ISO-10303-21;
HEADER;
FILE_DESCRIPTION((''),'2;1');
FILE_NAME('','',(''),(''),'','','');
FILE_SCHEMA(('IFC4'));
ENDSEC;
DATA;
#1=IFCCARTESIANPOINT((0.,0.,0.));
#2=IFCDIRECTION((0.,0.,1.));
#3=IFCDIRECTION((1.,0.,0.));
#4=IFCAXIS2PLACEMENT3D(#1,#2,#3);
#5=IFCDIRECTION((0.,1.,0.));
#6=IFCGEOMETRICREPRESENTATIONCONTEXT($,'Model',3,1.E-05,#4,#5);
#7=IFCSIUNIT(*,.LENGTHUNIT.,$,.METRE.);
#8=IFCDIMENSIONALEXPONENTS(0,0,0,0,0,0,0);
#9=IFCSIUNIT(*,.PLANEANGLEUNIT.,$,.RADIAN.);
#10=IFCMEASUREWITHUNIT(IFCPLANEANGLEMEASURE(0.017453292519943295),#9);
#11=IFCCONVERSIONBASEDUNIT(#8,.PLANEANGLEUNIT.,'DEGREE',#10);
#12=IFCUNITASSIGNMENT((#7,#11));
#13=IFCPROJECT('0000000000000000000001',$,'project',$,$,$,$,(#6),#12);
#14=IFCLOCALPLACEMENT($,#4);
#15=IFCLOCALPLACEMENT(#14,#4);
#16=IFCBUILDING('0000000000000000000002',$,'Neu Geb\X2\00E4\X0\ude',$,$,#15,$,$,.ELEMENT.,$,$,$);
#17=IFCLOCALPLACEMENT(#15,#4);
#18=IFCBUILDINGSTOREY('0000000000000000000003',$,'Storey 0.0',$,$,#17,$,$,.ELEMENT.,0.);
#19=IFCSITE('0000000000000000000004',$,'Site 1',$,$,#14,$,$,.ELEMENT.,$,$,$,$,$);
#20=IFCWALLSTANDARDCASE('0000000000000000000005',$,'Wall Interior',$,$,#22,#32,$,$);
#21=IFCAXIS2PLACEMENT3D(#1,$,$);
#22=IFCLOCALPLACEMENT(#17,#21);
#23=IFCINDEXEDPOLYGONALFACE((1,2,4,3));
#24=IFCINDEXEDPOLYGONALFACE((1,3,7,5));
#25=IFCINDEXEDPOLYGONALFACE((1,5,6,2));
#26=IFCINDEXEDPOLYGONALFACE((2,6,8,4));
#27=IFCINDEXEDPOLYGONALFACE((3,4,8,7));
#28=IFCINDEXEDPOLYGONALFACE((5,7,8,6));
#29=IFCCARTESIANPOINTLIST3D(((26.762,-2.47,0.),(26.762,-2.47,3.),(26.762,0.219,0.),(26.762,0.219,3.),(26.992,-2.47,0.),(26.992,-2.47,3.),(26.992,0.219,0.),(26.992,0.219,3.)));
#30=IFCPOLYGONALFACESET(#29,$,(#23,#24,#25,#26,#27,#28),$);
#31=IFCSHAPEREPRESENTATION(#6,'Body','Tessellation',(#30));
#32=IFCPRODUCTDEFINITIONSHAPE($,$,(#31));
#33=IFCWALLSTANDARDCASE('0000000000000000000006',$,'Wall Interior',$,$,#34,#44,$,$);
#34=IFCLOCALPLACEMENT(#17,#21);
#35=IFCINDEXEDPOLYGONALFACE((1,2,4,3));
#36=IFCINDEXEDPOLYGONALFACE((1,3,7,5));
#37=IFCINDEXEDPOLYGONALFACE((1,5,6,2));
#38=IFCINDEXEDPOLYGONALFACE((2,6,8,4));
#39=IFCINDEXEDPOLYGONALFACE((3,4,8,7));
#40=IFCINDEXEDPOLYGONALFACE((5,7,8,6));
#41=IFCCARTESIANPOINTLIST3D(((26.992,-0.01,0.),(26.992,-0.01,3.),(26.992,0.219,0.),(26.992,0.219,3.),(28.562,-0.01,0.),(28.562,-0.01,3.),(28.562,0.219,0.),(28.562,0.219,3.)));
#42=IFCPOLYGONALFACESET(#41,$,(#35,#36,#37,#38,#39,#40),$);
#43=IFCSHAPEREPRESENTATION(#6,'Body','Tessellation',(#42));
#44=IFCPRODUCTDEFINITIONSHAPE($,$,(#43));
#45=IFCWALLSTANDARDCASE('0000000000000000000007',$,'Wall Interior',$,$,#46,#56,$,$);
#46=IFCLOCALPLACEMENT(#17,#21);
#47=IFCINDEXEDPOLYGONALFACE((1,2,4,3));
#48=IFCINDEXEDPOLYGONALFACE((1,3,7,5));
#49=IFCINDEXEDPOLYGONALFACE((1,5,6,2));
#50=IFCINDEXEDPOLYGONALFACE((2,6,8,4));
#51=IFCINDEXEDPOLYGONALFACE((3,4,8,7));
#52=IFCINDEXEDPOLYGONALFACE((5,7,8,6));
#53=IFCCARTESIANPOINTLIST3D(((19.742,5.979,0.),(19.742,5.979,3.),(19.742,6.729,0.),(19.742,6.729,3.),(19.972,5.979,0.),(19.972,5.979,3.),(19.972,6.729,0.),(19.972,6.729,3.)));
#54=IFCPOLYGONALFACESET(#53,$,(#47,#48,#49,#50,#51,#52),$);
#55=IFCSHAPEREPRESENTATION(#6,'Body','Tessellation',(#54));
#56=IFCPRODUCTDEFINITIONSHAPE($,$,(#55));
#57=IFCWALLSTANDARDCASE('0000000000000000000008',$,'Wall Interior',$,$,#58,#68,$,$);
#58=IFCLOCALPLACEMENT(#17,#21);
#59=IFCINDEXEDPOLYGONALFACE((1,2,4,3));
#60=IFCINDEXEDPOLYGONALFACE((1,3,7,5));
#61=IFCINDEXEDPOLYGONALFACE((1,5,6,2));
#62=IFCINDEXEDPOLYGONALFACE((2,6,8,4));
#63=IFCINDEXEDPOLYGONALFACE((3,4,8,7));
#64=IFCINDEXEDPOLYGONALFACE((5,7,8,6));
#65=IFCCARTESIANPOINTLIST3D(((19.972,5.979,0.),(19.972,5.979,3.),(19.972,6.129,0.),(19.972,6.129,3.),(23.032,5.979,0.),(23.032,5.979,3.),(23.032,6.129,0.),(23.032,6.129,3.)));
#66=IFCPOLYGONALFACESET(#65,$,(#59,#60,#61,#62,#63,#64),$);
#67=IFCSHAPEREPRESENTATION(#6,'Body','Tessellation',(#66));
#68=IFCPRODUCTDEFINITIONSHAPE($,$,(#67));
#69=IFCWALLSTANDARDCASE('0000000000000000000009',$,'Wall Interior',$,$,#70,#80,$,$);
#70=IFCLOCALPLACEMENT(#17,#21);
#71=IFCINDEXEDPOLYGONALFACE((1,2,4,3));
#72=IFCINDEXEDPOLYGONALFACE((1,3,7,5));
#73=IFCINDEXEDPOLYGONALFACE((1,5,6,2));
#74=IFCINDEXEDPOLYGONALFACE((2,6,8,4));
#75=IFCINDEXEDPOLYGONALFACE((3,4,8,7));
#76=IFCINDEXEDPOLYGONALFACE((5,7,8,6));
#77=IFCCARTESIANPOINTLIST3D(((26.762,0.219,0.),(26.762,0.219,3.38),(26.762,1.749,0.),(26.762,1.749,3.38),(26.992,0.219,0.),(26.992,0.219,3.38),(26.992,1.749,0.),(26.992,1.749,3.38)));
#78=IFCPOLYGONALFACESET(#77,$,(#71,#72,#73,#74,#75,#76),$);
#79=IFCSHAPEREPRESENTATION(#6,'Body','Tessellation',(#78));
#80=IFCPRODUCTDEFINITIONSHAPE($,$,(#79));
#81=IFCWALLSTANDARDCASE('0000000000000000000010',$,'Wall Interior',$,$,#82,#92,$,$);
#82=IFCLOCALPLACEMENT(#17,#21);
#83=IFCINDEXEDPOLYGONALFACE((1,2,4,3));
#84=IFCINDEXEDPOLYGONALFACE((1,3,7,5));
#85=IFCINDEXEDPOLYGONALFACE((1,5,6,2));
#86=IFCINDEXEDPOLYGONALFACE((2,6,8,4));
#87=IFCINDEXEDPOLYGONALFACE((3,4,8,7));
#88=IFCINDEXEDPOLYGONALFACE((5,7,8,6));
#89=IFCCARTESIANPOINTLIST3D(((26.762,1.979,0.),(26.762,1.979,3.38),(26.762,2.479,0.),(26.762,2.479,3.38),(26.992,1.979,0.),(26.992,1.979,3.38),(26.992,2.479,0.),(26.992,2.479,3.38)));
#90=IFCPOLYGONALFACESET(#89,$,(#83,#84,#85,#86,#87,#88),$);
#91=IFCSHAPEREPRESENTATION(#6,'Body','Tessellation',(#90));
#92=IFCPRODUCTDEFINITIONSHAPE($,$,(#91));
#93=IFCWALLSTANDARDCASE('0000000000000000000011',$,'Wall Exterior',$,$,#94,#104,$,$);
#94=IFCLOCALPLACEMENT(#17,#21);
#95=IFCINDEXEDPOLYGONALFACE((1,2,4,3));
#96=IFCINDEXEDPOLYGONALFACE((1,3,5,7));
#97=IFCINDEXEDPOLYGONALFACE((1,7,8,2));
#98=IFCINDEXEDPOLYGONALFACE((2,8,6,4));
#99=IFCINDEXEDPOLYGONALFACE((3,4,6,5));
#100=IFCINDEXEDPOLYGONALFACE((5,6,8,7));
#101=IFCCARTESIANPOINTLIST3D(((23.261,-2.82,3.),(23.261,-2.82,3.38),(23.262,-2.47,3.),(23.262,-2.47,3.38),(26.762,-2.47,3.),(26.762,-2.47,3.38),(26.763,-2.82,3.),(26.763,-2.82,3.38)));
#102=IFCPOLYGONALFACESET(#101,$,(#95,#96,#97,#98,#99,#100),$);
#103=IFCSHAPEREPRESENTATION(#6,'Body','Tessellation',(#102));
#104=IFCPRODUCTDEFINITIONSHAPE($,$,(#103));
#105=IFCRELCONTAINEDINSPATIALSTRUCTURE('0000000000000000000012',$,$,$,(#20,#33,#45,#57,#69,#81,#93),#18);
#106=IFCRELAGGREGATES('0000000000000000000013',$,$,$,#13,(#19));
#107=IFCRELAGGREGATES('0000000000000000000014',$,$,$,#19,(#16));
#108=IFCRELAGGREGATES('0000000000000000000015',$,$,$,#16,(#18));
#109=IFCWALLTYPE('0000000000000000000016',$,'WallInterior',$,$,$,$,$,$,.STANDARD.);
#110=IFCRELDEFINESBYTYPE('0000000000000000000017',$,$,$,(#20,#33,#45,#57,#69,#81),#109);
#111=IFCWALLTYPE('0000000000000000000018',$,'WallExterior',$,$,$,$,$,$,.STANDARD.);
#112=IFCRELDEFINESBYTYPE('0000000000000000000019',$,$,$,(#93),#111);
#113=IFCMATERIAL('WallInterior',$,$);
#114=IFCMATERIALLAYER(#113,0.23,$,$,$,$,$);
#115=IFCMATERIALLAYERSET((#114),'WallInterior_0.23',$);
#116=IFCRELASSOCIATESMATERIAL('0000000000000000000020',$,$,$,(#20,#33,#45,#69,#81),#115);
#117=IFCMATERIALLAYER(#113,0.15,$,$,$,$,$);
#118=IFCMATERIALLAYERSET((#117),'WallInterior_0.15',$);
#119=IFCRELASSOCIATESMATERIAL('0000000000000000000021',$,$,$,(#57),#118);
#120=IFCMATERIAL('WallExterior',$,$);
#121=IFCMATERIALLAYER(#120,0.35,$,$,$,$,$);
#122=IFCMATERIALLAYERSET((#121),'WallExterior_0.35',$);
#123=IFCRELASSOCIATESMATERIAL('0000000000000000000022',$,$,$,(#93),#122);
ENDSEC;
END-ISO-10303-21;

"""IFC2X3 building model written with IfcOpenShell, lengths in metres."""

from ifc_helpers import new_model, entity, si_unit, converted_unit, direction, frame, origin_with_axes, place, context, project, spatial, polyline, outline, extrude, material, layer, layer_set, layer_usage, type_object, element, save


model = new_model("IFC2X3")

# Units and contexts
model_context = context("Model", 3, precision=1e-05, world=origin_with_axes(), true_north=direction((0.0, 1.0, 0.0)))
ifc_project = project(units=[si_unit("LENGTHUNIT", "METRE"), converted_unit("PLANEANGLEUNIT", "DEGREE", entity("IfcPlaneAngleMeasure", 0.017453292519943295), si_unit("PLANEANGLEUNIT", "RADIAN"), dimensions=[0, 0, 0, 0, 0, 0, 0])], contexts=[model_context])

# Site, building, storey
site_placement = place(None, origin_with_axes())
site = spatial("IfcSite", under=ifc_project, at=site_placement, Name="Site 1", CompositionType="ELEMENT")
building_placement = place(site_placement, origin_with_axes())
building = spatial("IfcBuilding", under=site, at=building_placement, Name="Neu Gebäude", CompositionType="ELEMENT")
storey_placement = place(building_placement, origin_with_axes())
storey = spatial("IfcBuildingStorey", under=building, at=storey_placement, Name="Storey 0.0", CompositionType="ELEMENT", Elevation=0.0)

# Walls
ifc_material_1 = material(Name="WallInterior")
ifc_layer_1 = layer(ifc_material_1, 0.23)
ifc_layer_set_1 = layer_set([ifc_layer_1], Name="WallInterior_0.23")
ifc_layer_usage_1 = layer_usage(ifc_layer_set_1, "AXIS2", "POSITIVE", -0.115)
wall_type_1 = type_object("IfcWallType", Name="WallInterior", PredefinedType="STANDARD")
wall_1_placement = place(storey_placement, frame((26.877, -2.47, 0.0), z_axis=(0.0, 0.0, 1.0), x_axis=(0.0, 1.0, 0.0)))
element("IfcWallStandardCase", 1, at=wall_1_placement, inside=storey, type_object=wall_type_1, material=ifc_layer_usage_1, Name="Wall Interior", context=model_context, shape_type="SweptSolid", body=[
    extrude(outline(polyline([(2.689, -0.115), (2.689, 0.115), (0.0, 0.115), (0.0, -0.115), (2.689, -0.115)])), origin_with_axes(), (0.0, 0.0, 1.0), 3.0),
])
wall_2_placement = place(storey_placement, frame((28.562, 0.1045, 0.0), z_axis=(0.0, 0.0, 1.0), x_axis=(-1.0, 0.0, 0.0)))
element("IfcWallStandardCase", 2, at=wall_2_placement, inside=storey, type_object=wall_type_1, material=ifc_layer_usage_1, Name="Wall Interior", context=model_context, shape_type="SweptSolid", body=[
    extrude(outline(polyline([(0.0, -0.1145), (1.57, -0.1145), (1.57, 0.1145), (0.0, 0.1145), (0.0, -0.1145)])), origin_with_axes(), (0.0, 0.0, 1.0), 3.0),
])

# Walls
wall_3_placement = place(storey_placement, frame((19.857, 5.979, 0.0), z_axis=(0.0, 0.0, 1.0), x_axis=(0.0, 1.0, 0.0)))
element("IfcWallStandardCase", 3, at=wall_3_placement, inside=storey, type_object=wall_type_1, material=ifc_layer_usage_1, Name="Wall Interior", context=model_context, shape_type="SweptSolid", body=[
    extrude(outline(polyline([(0.75, -0.115), (0.75, 0.115), (0.0, 0.115), (0.0, -0.115), (0.75, -0.115)])), origin_with_axes(), (0.0, 0.0, 1.0), 3.0),
])
ifc_layer_2 = layer(ifc_material_1, 0.15)
ifc_layer_set_2 = layer_set([ifc_layer_2], Name="WallInterior_0.15")
ifc_layer_usage_2 = layer_usage(ifc_layer_set_2, "AXIS2", "POSITIVE", -0.075)
wall_4_placement = place(storey_placement, frame((23.032, 6.054, 0.0), z_axis=(0.0, 0.0, 1.0), x_axis=(-1.0, 0.0, 0.0)))
element("IfcWallStandardCase", 4, at=wall_4_placement, inside=storey, type_object=wall_type_1, material=ifc_layer_usage_2, Name="Wall Interior", context=model_context, shape_type="SweptSolid", body=[
    extrude(outline(polyline([(0.0, 0.075), (0.0, -0.075), (3.06, -0.075), (3.06, 0.075), (0.0, 0.075)])), origin_with_axes(), (0.0, 0.0, 1.0), 3.0),
])
wall_5_placement = place(storey_placement, frame((26.877, 0.219, 0.0), z_axis=(0.0, 0.0, 1.0), x_axis=(0.0, 1.0, 0.0)))
element("IfcWallStandardCase", 5, at=wall_5_placement, inside=storey, type_object=wall_type_1, material=ifc_layer_usage_1, Name="Wall Interior", context=model_context, shape_type="SweptSolid", body=[
    extrude(outline(polyline([(1.53, -0.115), (1.53, 0.115), (0.0, 0.115), (0.0, -0.115), (1.53, -0.115)])), origin_with_axes(), (0.0, 0.0, 1.0), 3.38),
])
wall_6_placement = place(storey_placement, frame((26.877, 1.979, 0.0), z_axis=(0.0, 0.0, 1.0), x_axis=(0.0, 1.0, 0.0)))
element("IfcWallStandardCase", 6, at=wall_6_placement, inside=storey, type_object=wall_type_1, material=ifc_layer_usage_1, Name="Wall Interior", context=model_context, shape_type="SweptSolid", body=[
    extrude(outline(polyline([(0.5, -0.115), (0.5, 0.115), (0.0, 0.115), (0.0, -0.115), (0.5, -0.115)])), origin_with_axes(), (0.0, 0.0, 1.0), 3.38),
])

# Shared definitions
ifc_material_2 = material(Name="WallExterior")
ifc_layer_3 = layer(ifc_material_2, 0.35)
ifc_layer_set_3 = layer_set([ifc_layer_3], Name="WallExterior_0.35")
ifc_layer_usage_3 = layer_usage(ifc_layer_set_3, "AXIS2", "POSITIVE", -0.175)
wall_type_2 = type_object("IfcWallType", Name="WallExterior", PredefinedType="STANDARD")

# Wall
wall_7_placement = place(storey_placement, frame((26.763, -2.645, 3.0), z_axis=(0.0, 0.0, 1.0), x_axis=(-1.0, 0.0, 0.0)))
element("IfcWallStandardCase", 7, at=wall_7_placement, inside=storey, type_object=wall_type_2, material=ifc_layer_usage_3, Name="Wall Exterior", context=model_context, shape_type="SweptSolid", body=[
    extrude(outline(polyline([(0.001, -0.175), (3.501, -0.175), (3.502, 0.175), (0.0, 0.175), (0.001, -0.175)])), origin_with_axes(), (0.0, 0.0, 1.0), 0.38),
])

save(model, "model.ifc")
